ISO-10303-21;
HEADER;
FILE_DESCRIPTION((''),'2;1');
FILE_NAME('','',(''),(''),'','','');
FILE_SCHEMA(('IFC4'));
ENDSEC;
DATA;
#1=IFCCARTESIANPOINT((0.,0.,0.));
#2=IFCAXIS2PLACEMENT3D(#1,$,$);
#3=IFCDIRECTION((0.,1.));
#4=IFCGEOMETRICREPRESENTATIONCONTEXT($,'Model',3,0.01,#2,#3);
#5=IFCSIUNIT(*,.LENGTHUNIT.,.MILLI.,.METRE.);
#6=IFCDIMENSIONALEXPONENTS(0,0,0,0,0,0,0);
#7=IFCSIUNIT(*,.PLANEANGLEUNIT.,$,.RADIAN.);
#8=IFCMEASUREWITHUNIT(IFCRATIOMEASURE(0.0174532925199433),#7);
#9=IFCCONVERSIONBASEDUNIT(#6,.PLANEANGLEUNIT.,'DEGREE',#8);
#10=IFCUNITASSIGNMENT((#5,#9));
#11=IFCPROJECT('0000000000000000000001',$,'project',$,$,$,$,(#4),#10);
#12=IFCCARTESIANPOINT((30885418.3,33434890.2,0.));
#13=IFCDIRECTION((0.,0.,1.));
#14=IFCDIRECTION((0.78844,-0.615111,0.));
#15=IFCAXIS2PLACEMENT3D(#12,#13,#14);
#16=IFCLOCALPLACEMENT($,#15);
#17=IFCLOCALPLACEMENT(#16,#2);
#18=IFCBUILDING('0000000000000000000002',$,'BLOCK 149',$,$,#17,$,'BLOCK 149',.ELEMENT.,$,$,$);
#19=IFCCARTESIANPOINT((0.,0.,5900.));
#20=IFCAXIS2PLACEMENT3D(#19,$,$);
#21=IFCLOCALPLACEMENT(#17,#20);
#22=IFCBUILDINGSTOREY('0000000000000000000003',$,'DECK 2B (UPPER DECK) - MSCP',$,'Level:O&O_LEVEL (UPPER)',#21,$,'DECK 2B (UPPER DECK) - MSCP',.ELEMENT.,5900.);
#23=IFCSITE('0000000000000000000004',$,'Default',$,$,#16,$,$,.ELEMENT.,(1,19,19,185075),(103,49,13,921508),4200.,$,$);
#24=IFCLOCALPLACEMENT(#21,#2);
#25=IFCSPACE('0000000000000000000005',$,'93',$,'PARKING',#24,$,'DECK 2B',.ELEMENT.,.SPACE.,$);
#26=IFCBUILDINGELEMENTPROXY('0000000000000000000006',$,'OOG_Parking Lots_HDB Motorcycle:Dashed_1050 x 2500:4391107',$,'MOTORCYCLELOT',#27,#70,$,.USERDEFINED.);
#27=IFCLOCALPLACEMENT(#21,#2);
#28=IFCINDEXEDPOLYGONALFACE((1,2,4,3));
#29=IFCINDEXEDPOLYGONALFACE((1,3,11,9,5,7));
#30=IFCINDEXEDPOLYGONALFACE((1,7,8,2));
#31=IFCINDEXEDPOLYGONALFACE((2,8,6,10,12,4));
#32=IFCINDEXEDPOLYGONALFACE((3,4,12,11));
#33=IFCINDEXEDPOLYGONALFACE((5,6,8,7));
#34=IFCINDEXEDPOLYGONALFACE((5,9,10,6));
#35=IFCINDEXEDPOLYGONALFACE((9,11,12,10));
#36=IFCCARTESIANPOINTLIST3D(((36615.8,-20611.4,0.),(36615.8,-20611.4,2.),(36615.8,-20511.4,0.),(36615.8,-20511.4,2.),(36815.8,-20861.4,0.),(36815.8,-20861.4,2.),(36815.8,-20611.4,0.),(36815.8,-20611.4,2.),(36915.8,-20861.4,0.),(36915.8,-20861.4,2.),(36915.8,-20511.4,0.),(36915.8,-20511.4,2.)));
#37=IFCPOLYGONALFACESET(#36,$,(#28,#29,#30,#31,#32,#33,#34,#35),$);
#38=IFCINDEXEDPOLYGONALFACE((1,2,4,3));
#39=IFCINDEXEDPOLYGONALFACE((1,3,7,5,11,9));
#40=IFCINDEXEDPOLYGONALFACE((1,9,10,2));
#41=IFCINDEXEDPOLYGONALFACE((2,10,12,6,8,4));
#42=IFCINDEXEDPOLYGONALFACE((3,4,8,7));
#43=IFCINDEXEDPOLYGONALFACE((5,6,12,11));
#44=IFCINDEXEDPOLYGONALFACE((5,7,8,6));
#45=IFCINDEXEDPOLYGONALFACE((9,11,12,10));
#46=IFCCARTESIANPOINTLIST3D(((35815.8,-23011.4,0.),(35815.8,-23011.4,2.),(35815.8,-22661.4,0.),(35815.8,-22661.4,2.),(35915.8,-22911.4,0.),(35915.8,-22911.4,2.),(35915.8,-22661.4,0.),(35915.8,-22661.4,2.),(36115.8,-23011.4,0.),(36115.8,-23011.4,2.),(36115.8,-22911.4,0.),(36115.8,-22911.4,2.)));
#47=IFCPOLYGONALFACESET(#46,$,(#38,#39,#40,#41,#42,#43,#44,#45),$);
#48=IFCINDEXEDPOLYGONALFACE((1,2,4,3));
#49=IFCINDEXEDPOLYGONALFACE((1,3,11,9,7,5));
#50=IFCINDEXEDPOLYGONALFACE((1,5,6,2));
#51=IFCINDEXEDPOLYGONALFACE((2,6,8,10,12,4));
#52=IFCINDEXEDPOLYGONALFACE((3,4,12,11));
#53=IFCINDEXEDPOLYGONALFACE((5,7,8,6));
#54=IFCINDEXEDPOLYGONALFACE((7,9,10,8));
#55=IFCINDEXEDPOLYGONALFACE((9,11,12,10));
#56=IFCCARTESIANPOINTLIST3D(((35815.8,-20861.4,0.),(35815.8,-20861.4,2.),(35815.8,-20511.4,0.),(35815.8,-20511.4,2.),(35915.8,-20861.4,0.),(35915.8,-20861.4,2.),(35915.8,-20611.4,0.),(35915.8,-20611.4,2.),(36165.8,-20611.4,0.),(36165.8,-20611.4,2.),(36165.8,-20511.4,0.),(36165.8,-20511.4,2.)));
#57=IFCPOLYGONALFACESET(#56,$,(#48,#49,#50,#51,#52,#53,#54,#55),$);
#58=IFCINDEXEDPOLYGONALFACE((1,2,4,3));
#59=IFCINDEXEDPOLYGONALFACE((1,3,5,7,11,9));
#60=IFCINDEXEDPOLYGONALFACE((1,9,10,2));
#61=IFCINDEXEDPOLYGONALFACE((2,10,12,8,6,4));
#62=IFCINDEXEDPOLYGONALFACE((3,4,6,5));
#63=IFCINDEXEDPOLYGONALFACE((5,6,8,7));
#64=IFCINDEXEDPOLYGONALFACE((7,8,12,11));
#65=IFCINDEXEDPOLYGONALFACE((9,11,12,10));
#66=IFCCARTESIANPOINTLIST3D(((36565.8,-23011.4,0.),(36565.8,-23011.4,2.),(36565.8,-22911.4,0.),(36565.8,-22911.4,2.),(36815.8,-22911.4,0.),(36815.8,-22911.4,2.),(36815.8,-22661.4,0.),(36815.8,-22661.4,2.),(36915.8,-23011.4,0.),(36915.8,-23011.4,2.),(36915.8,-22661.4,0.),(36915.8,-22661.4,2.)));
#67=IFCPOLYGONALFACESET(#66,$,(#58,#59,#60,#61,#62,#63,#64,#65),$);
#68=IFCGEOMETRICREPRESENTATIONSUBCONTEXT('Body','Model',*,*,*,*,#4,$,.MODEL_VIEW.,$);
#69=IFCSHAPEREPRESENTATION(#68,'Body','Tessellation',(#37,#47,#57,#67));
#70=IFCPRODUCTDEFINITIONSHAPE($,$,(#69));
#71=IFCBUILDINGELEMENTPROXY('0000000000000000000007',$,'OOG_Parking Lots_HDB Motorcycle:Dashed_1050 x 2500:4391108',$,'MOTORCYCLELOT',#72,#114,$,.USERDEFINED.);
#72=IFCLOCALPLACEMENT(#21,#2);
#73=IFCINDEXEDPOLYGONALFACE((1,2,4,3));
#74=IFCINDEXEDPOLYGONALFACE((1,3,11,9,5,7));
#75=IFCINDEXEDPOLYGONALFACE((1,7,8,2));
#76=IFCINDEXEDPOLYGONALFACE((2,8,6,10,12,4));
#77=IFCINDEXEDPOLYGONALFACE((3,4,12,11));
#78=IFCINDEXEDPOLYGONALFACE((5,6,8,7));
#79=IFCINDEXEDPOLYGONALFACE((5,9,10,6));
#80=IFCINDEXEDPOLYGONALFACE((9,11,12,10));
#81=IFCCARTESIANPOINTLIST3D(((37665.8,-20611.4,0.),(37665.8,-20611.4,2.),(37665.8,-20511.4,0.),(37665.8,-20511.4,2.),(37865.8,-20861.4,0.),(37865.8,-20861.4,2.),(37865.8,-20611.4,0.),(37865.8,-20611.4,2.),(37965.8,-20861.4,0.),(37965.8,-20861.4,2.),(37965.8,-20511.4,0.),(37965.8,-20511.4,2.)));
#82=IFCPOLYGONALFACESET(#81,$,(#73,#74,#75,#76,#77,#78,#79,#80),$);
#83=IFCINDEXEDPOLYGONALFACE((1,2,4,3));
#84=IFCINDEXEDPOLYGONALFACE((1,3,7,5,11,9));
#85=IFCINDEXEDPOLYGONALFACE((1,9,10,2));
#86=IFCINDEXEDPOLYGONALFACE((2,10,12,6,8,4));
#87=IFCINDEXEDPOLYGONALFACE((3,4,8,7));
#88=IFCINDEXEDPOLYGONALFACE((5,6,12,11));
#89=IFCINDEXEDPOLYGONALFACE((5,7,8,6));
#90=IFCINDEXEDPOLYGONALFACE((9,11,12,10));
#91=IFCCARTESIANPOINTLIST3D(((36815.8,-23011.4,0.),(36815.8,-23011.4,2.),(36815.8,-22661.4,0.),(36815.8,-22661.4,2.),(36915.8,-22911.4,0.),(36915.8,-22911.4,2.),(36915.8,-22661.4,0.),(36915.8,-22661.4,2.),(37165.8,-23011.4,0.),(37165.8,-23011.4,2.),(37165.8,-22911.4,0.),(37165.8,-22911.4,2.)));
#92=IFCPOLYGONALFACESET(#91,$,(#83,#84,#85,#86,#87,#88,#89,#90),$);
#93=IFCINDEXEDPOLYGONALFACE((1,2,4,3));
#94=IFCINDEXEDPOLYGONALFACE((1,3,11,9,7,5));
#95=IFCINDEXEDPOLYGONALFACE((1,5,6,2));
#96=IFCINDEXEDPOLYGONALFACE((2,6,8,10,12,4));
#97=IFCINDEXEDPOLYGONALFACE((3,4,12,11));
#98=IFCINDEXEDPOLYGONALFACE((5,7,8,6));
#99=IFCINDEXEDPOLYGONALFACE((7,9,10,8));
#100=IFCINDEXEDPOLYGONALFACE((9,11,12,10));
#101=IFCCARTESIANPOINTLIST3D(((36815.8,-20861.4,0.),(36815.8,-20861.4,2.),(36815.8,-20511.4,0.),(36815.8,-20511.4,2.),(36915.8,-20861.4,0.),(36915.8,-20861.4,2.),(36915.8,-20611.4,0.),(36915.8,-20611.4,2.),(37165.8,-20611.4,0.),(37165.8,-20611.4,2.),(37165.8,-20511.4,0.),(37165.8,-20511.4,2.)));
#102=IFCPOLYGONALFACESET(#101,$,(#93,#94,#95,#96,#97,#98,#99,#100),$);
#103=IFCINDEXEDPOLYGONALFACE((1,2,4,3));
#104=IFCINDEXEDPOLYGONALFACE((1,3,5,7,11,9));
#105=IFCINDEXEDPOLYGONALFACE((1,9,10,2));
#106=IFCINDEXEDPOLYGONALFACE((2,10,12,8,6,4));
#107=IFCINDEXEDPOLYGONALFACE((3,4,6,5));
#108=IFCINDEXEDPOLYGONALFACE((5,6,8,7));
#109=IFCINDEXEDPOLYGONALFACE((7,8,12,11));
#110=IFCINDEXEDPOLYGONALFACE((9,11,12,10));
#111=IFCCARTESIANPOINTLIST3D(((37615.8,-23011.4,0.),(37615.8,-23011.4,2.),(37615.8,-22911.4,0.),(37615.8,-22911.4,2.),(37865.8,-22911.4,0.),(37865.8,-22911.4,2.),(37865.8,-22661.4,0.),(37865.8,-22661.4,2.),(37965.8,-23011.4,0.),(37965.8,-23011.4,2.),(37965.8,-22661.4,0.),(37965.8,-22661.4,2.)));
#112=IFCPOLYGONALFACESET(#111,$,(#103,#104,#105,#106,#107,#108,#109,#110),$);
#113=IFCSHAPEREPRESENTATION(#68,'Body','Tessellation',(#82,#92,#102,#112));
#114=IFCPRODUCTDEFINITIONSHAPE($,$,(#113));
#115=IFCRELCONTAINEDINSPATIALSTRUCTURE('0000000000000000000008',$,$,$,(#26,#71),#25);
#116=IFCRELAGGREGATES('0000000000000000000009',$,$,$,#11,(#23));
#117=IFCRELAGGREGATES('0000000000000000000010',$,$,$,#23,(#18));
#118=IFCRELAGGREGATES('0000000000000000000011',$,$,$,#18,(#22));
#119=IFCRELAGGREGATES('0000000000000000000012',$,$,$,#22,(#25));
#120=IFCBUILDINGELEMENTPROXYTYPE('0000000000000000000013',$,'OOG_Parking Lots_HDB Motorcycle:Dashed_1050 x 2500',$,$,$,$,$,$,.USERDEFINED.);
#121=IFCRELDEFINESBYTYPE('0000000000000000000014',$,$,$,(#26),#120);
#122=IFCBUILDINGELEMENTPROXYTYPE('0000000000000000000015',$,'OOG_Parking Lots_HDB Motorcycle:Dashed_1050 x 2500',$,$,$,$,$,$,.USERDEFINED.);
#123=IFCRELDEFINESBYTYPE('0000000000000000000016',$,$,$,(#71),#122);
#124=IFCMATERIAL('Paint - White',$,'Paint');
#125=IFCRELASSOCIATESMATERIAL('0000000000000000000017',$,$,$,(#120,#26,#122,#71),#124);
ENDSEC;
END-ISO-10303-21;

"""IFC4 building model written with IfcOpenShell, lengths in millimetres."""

from ifc_helpers import new_model, entity, si_unit, converted_unit, direction, frame, origin, place, context, subcontext, project, spatial, indexed_curve, outline, extrude, source, transform, mapped, material, type_object, type_shapes, element, save


model = new_model("IFC4")

# Units and contexts
model_context = context("Model", 3, precision=0.01, world=origin(), true_north=direction((0.0, 1.0)))
body_context = subcontext(model_context, "Body", "Model", "MODEL_VIEW")
ifc_project = project(units=[si_unit("LENGTHUNIT", "METRE", prefix="MILLI"), converted_unit("PLANEANGLEUNIT", "DEGREE", entity("IfcRatioMeasure", 0.0174532925199433), si_unit("PLANEANGLEUNIT", "RADIAN"), dimensions=[0, 0, 0, 0, 0, 0, 0])], contexts=[model_context])

# Site, building, storey
site_placement = place(None, frame((30885418.3, 33434890.2, 0.0), z_axis=(0.0, 0.0, 1.0), x_axis=(0.78844, -0.615111, 0.0)))
site = spatial("IfcSite", under=ifc_project, at=site_placement, Name="Default", CompositionType="ELEMENT", RefLatitude=(1, 19, 19, 185075), RefLongitude=(103, 49, 13, 921508), RefElevation=4200.0)
building_placement = place(site_placement, origin())
building = spatial("IfcBuilding", under=site, at=building_placement, Name="BLOCK 149", LongName="BLOCK 149", CompositionType="ELEMENT")
storey_placement = place(building_placement, frame((0.0, 0.0, 5900.0)))
storey = spatial("IfcBuildingStorey", under=building, at=storey_placement, Name="DECK 2B (UPPER DECK) - MSCP", ObjectType="Level:O&O_LEVEL (UPPER)", LongName="DECK 2B (UPPER DECK) - MSCP", CompositionType="ELEMENT", Elevation=5900.0)

# Shared definitions
space_placement = place(storey_placement, origin())
space = spatial("IfcSpace", under=storey, at=space_placement, Name="93", ObjectType="PARKING", LongName="DECK 2B", CompositionType="ELEMENT", PredefinedType="SPACE")

# Building element proxies
ifc_material_1 = material(Name="Paint - White", Category="Paint")
building_element_proxy_type_1 = type_object("IfcBuildingElementProxyType", Name="OOG_Parking Lots_HDB Motorcycle:Dashed_1050 x 2500", PredefinedType="USERDEFINED", material=ifc_material_1)
shared_shape_1 = source(origin(), body_context, "Body", "SweptSolid", [
    extrude(outline(indexed_curve([(-200.0, -133.3), (150.0, -133.3), (150.0, 166.7), (50.0, 166.7), (50.0, -33.3), (-200.0, -33.3), (-200.0, -133.3)], self_intersect=False)), frame((916.7, -100.0, 0.0), z_axis=(0.0, 0.0, 1.0), x_axis=(0.0, 1.0, 0.0)), (0.0, 0.0, 1.0), 2.0),
    extrude(outline(indexed_curve([(-200.0, -133.3), (150.0, -133.3), (150.0, 166.7), (50.0, 166.7), (50.0, -33.3), (-200.0, -33.3), (-200.0, -133.3)], self_intersect=False)), frame((83.3, -2300.0, 0.0), z_axis=(0.0, 0.0, 1.0), x_axis=(0.0, -1.0, 0.0)), (0.0, 0.0, 1.0), 2.0),
    extrude(outline(indexed_curve([(-200.0, -150.0), (150.0, -150.0), (150.0, 200.0), (50.0, 200.0), (50.0, -50.0), (-200.0, -50.0), (-200.0, -150.0)], self_intersect=False)), frame((100.0, -100.0, 0.0), z_axis=(0.0, 0.0, 1.0), x_axis=(-1.0, 0.0, 0.0)), (0.0, 0.0, 1.0), 2.0),
    extrude(outline(indexed_curve([(-200.0, -150.0), (150.0, -150.0), (150.0, 200.0), (50.0, 200.0), (50.0, -50.0), (-200.0, -50.0), (-200.0, -150.0)], self_intersect=False)), frame((900.0, -2300.0, 0.0)), (0.0, 0.0, 1.0), 2.0),
])
type_shapes(building_element_proxy_type_1, [shared_shape_1])
proxy_1_placement = place(space_placement, frame((35865.8, -20561.4, 0.0)))
element("IfcBuildingElementProxy", 1, at=proxy_1_placement, inside=space, type_object=building_element_proxy_type_1, material=ifc_material_1, Name="OOG_Parking Lots_HDB Motorcycle:Dashed_1050 x 2500:4391107", ObjectType="MOTORCYCLELOT", PredefinedType="USERDEFINED", context=body_context, shape_type="MappedRepresentation", body=[
    mapped(shared_shape_1, transform((0.0, 0.0, 0.0), scale=1.0)),
])
building_element_proxy_type_2 = type_object("IfcBuildingElementProxyType", Name="OOG_Parking Lots_HDB Motorcycle:Dashed_1050 x 2500", PredefinedType="USERDEFINED", material=ifc_material_1)
shared_shape_2 = source(origin(), body_context, "Body", "SweptSolid", [
    extrude(outline(indexed_curve([(-200.0, -133.3), (150.0, -133.3), (150.0, 166.7), (50.0, 166.7), (50.0, -33.3), (-200.0, -33.3), (-200.0, -133.3)], self_intersect=False)), frame((966.7, -100.0, 0.0), z_axis=(0.0, 0.0, 1.0), x_axis=(0.0, 1.0, 0.0)), (0.0, 0.0, 1.0), 2.0),
    extrude(outline(indexed_curve([(-200.0, -150.0), (150.0, -150.0), (150.0, 200.0), (50.0, 200.0), (50.0, -50.0), (-200.0, -50.0), (-200.0, -150.0)], self_intersect=False)), frame((100.0, -2300.0, 0.0), z_axis=(0.0, 0.0, 1.0), x_axis=(0.0, -1.0, 0.0)), (0.0, 0.0, 1.0), 2.0),
    extrude(outline(indexed_curve([(-200.0, -150.0), (150.0, -150.0), (150.0, 200.0), (50.0, 200.0), (50.0, -50.0), (-200.0, -50.0), (-200.0, -150.0)], self_intersect=False)), frame((100.0, -100.0, 0.0), z_axis=(0.0, 0.0, 1.0), x_axis=(-1.0, 0.0, 0.0)), (0.0, 0.0, 1.0), 2.0),
    extrude(outline(indexed_curve([(-200.0, -150.0), (150.0, -150.0), (150.0, 200.0), (50.0, 200.0), (50.0, -50.0), (-200.0, -50.0), (-200.0, -150.0)], self_intersect=False)), frame((950.0, -2300.0, 0.0)), (0.0, 0.0, 1.0), 2.0),
])
type_shapes(building_element_proxy_type_2, [shared_shape_2])
proxy_2_placement = place(space_placement, frame((36865.8, -20561.4, 0.0)))
element("IfcBuildingElementProxy", 2, at=proxy_2_placement, inside=space, type_object=building_element_proxy_type_2, material=ifc_material_1, Name="OOG_Parking Lots_HDB Motorcycle:Dashed_1050 x 2500:4391108", ObjectType="MOTORCYCLELOT", PredefinedType="USERDEFINED", context=body_context, shape_type="MappedRepresentation", body=[
    mapped(shared_shape_2, transform((0.0, 0.0, 0.0), scale=1.0)),
])

save(model, "model.ifc")
